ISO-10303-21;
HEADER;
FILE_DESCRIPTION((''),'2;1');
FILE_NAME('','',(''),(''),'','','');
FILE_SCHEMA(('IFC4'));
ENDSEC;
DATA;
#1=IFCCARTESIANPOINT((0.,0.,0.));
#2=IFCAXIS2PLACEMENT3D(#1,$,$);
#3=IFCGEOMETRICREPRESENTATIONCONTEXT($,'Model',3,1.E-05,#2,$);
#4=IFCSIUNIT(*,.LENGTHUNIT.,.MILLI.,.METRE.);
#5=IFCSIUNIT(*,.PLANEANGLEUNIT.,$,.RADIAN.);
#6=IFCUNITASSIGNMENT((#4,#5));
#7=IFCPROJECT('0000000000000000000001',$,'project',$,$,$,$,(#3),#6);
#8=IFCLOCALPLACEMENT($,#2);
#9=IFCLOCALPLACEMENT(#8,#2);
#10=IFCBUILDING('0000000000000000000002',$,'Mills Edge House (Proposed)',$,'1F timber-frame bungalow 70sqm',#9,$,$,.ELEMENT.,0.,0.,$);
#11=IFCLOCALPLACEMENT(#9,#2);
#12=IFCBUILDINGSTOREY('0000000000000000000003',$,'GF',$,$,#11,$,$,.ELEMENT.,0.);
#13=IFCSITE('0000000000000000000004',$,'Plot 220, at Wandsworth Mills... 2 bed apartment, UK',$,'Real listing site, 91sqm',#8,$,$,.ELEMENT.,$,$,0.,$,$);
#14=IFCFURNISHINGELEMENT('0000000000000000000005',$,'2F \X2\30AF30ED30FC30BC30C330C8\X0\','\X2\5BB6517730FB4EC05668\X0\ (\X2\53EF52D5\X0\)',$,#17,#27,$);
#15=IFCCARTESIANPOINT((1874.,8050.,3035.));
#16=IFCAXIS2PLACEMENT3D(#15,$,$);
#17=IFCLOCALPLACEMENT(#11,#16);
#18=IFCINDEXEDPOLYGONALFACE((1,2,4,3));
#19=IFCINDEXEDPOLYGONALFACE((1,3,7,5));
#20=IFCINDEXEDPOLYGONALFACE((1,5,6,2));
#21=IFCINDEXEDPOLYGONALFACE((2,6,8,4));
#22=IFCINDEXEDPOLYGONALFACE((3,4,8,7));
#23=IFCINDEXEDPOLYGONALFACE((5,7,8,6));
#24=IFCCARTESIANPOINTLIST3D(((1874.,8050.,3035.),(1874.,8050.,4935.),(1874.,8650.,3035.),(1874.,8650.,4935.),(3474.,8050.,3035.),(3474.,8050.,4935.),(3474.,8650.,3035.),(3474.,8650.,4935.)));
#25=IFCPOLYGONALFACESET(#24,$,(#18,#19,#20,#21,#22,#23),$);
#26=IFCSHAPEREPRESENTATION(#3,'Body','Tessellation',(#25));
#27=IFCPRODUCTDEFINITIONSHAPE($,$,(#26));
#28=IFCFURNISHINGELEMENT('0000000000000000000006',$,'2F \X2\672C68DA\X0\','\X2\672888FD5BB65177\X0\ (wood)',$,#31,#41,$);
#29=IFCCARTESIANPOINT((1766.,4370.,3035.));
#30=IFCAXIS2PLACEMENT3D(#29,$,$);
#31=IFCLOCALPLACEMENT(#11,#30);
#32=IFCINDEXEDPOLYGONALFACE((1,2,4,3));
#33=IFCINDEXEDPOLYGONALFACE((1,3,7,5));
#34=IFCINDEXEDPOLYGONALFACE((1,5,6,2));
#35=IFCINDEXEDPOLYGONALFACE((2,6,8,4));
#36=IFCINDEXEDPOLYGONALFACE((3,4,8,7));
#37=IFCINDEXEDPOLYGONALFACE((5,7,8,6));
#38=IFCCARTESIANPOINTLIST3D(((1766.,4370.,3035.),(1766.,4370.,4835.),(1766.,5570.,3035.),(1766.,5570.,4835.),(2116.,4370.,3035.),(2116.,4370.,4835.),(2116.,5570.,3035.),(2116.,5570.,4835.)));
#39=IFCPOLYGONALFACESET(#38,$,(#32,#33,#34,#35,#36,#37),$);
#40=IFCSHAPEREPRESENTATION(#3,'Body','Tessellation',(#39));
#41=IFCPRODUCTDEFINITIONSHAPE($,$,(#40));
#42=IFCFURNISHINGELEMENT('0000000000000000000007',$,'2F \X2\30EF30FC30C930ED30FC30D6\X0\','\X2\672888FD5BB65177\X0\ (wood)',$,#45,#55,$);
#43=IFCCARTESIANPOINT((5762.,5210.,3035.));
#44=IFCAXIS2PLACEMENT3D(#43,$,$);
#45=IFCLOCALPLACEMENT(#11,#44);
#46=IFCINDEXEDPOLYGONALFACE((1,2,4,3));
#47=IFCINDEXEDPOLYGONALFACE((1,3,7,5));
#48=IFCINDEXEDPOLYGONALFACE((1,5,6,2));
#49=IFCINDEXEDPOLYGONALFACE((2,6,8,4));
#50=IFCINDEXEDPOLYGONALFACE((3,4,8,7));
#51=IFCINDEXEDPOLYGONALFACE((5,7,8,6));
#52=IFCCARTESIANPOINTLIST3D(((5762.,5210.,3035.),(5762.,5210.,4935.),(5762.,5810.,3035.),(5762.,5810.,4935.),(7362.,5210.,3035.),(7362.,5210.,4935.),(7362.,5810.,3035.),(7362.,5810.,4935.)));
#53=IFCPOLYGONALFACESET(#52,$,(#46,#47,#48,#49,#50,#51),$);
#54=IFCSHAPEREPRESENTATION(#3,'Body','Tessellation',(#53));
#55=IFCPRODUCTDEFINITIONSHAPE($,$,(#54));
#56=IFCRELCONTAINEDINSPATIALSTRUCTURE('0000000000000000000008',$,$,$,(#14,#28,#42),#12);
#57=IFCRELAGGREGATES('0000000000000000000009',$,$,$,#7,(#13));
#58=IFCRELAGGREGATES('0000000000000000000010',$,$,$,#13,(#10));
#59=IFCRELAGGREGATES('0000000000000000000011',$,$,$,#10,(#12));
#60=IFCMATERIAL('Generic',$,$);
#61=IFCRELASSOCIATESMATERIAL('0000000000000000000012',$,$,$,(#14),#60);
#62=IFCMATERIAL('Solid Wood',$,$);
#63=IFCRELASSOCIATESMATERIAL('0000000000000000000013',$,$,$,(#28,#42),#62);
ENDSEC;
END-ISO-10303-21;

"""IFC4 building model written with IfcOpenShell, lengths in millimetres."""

from ifc_helpers import new_model, si_unit, frame, frame_2d, origin, place, context, project, spatial, rectangle, extrude, material, element, save


model = new_model("IFC4")

# Units and contexts
model_context = context("Model", 3, precision=1e-05, world=origin())
ifc_project = project(units=[si_unit("LENGTHUNIT", "METRE", prefix="MILLI"), si_unit("PLANEANGLEUNIT", "RADIAN")], contexts=[model_context])

# Site, building, storey
site_placement = place(None, origin())
site = spatial("IfcSite", under=ifc_project, at=site_placement, Name="Plot 220, at Wandsworth Mills... 2 bed apartment, UK", ObjectType="Real listing site, 91sqm", CompositionType="ELEMENT", RefElevation=0.0)
building_placement = place(site_placement, origin())
building = spatial("IfcBuilding", under=site, at=building_placement, Name="Mills Edge House (Proposed)", ObjectType="1F timber-frame bungalow 70sqm", CompositionType="ELEMENT", ElevationOfRefHeight=0.0, ElevationOfTerrain=0.0)
storey_placement = place(building_placement, origin())
storey = spatial("IfcBuildingStorey", under=building, at=storey_placement, Name="GF", CompositionType="ELEMENT", Elevation=0.0)

# Shared definitions
ifc_material_1 = material(Name="Solid Wood")

# Shared definitions
ifc_material_2 = material(Name="Generic")

# Furnishing elements
furnishing_1_placement = place(storey_placement, frame((1874.0, 8050.0, 3035.0)))
element("IfcFurnishingElement", 1, at=furnishing_1_placement, inside=storey, material=ifc_material_2, Name="2F クローゼット", Description="家具・什器 (可動)", context=model_context, shape_type="SweptSolid", body=[
    extrude(rectangle(XDim=1600.0, YDim=600.0, at=frame_2d((800.0, 300.0))), frame((1874.0, 8050.0, 3035.0)), (0.0, 0.0, 1.0), 1900.0),
])
furnishing_2_placement = place(storey_placement, frame((1766.0, 4370.0, 3035.0)))
element("IfcFurnishingElement", 2, at=furnishing_2_placement, inside=storey, material=ifc_material_1, Name="2F 本棚", Description="木製家具 (wood)", context=model_context, shape_type="SweptSolid", body=[
    extrude(rectangle(XDim=350.0, YDim=1200.0, at=frame_2d((175.0, 600.0))), frame((1766.0, 4370.0, 3035.0)), (0.0, 0.0, 1.0), 1800.0),
])
furnishing_3_placement = place(storey_placement, frame((5762.0, 5210.0, 3035.0)))
element("IfcFurnishingElement", 3, at=furnishing_3_placement, inside=storey, material=ifc_material_1, Name="2F ワードローブ", Description="木製家具 (wood)", context=model_context, shape_type="SweptSolid", body=[
    extrude(rectangle(XDim=1600.0, YDim=600.0, at=frame_2d((800.0, 300.0))), frame((5762.0, 5210.0, 3035.0)), (0.0, 0.0, 1.0), 1900.0),
])

save(model, "model.ifc")
